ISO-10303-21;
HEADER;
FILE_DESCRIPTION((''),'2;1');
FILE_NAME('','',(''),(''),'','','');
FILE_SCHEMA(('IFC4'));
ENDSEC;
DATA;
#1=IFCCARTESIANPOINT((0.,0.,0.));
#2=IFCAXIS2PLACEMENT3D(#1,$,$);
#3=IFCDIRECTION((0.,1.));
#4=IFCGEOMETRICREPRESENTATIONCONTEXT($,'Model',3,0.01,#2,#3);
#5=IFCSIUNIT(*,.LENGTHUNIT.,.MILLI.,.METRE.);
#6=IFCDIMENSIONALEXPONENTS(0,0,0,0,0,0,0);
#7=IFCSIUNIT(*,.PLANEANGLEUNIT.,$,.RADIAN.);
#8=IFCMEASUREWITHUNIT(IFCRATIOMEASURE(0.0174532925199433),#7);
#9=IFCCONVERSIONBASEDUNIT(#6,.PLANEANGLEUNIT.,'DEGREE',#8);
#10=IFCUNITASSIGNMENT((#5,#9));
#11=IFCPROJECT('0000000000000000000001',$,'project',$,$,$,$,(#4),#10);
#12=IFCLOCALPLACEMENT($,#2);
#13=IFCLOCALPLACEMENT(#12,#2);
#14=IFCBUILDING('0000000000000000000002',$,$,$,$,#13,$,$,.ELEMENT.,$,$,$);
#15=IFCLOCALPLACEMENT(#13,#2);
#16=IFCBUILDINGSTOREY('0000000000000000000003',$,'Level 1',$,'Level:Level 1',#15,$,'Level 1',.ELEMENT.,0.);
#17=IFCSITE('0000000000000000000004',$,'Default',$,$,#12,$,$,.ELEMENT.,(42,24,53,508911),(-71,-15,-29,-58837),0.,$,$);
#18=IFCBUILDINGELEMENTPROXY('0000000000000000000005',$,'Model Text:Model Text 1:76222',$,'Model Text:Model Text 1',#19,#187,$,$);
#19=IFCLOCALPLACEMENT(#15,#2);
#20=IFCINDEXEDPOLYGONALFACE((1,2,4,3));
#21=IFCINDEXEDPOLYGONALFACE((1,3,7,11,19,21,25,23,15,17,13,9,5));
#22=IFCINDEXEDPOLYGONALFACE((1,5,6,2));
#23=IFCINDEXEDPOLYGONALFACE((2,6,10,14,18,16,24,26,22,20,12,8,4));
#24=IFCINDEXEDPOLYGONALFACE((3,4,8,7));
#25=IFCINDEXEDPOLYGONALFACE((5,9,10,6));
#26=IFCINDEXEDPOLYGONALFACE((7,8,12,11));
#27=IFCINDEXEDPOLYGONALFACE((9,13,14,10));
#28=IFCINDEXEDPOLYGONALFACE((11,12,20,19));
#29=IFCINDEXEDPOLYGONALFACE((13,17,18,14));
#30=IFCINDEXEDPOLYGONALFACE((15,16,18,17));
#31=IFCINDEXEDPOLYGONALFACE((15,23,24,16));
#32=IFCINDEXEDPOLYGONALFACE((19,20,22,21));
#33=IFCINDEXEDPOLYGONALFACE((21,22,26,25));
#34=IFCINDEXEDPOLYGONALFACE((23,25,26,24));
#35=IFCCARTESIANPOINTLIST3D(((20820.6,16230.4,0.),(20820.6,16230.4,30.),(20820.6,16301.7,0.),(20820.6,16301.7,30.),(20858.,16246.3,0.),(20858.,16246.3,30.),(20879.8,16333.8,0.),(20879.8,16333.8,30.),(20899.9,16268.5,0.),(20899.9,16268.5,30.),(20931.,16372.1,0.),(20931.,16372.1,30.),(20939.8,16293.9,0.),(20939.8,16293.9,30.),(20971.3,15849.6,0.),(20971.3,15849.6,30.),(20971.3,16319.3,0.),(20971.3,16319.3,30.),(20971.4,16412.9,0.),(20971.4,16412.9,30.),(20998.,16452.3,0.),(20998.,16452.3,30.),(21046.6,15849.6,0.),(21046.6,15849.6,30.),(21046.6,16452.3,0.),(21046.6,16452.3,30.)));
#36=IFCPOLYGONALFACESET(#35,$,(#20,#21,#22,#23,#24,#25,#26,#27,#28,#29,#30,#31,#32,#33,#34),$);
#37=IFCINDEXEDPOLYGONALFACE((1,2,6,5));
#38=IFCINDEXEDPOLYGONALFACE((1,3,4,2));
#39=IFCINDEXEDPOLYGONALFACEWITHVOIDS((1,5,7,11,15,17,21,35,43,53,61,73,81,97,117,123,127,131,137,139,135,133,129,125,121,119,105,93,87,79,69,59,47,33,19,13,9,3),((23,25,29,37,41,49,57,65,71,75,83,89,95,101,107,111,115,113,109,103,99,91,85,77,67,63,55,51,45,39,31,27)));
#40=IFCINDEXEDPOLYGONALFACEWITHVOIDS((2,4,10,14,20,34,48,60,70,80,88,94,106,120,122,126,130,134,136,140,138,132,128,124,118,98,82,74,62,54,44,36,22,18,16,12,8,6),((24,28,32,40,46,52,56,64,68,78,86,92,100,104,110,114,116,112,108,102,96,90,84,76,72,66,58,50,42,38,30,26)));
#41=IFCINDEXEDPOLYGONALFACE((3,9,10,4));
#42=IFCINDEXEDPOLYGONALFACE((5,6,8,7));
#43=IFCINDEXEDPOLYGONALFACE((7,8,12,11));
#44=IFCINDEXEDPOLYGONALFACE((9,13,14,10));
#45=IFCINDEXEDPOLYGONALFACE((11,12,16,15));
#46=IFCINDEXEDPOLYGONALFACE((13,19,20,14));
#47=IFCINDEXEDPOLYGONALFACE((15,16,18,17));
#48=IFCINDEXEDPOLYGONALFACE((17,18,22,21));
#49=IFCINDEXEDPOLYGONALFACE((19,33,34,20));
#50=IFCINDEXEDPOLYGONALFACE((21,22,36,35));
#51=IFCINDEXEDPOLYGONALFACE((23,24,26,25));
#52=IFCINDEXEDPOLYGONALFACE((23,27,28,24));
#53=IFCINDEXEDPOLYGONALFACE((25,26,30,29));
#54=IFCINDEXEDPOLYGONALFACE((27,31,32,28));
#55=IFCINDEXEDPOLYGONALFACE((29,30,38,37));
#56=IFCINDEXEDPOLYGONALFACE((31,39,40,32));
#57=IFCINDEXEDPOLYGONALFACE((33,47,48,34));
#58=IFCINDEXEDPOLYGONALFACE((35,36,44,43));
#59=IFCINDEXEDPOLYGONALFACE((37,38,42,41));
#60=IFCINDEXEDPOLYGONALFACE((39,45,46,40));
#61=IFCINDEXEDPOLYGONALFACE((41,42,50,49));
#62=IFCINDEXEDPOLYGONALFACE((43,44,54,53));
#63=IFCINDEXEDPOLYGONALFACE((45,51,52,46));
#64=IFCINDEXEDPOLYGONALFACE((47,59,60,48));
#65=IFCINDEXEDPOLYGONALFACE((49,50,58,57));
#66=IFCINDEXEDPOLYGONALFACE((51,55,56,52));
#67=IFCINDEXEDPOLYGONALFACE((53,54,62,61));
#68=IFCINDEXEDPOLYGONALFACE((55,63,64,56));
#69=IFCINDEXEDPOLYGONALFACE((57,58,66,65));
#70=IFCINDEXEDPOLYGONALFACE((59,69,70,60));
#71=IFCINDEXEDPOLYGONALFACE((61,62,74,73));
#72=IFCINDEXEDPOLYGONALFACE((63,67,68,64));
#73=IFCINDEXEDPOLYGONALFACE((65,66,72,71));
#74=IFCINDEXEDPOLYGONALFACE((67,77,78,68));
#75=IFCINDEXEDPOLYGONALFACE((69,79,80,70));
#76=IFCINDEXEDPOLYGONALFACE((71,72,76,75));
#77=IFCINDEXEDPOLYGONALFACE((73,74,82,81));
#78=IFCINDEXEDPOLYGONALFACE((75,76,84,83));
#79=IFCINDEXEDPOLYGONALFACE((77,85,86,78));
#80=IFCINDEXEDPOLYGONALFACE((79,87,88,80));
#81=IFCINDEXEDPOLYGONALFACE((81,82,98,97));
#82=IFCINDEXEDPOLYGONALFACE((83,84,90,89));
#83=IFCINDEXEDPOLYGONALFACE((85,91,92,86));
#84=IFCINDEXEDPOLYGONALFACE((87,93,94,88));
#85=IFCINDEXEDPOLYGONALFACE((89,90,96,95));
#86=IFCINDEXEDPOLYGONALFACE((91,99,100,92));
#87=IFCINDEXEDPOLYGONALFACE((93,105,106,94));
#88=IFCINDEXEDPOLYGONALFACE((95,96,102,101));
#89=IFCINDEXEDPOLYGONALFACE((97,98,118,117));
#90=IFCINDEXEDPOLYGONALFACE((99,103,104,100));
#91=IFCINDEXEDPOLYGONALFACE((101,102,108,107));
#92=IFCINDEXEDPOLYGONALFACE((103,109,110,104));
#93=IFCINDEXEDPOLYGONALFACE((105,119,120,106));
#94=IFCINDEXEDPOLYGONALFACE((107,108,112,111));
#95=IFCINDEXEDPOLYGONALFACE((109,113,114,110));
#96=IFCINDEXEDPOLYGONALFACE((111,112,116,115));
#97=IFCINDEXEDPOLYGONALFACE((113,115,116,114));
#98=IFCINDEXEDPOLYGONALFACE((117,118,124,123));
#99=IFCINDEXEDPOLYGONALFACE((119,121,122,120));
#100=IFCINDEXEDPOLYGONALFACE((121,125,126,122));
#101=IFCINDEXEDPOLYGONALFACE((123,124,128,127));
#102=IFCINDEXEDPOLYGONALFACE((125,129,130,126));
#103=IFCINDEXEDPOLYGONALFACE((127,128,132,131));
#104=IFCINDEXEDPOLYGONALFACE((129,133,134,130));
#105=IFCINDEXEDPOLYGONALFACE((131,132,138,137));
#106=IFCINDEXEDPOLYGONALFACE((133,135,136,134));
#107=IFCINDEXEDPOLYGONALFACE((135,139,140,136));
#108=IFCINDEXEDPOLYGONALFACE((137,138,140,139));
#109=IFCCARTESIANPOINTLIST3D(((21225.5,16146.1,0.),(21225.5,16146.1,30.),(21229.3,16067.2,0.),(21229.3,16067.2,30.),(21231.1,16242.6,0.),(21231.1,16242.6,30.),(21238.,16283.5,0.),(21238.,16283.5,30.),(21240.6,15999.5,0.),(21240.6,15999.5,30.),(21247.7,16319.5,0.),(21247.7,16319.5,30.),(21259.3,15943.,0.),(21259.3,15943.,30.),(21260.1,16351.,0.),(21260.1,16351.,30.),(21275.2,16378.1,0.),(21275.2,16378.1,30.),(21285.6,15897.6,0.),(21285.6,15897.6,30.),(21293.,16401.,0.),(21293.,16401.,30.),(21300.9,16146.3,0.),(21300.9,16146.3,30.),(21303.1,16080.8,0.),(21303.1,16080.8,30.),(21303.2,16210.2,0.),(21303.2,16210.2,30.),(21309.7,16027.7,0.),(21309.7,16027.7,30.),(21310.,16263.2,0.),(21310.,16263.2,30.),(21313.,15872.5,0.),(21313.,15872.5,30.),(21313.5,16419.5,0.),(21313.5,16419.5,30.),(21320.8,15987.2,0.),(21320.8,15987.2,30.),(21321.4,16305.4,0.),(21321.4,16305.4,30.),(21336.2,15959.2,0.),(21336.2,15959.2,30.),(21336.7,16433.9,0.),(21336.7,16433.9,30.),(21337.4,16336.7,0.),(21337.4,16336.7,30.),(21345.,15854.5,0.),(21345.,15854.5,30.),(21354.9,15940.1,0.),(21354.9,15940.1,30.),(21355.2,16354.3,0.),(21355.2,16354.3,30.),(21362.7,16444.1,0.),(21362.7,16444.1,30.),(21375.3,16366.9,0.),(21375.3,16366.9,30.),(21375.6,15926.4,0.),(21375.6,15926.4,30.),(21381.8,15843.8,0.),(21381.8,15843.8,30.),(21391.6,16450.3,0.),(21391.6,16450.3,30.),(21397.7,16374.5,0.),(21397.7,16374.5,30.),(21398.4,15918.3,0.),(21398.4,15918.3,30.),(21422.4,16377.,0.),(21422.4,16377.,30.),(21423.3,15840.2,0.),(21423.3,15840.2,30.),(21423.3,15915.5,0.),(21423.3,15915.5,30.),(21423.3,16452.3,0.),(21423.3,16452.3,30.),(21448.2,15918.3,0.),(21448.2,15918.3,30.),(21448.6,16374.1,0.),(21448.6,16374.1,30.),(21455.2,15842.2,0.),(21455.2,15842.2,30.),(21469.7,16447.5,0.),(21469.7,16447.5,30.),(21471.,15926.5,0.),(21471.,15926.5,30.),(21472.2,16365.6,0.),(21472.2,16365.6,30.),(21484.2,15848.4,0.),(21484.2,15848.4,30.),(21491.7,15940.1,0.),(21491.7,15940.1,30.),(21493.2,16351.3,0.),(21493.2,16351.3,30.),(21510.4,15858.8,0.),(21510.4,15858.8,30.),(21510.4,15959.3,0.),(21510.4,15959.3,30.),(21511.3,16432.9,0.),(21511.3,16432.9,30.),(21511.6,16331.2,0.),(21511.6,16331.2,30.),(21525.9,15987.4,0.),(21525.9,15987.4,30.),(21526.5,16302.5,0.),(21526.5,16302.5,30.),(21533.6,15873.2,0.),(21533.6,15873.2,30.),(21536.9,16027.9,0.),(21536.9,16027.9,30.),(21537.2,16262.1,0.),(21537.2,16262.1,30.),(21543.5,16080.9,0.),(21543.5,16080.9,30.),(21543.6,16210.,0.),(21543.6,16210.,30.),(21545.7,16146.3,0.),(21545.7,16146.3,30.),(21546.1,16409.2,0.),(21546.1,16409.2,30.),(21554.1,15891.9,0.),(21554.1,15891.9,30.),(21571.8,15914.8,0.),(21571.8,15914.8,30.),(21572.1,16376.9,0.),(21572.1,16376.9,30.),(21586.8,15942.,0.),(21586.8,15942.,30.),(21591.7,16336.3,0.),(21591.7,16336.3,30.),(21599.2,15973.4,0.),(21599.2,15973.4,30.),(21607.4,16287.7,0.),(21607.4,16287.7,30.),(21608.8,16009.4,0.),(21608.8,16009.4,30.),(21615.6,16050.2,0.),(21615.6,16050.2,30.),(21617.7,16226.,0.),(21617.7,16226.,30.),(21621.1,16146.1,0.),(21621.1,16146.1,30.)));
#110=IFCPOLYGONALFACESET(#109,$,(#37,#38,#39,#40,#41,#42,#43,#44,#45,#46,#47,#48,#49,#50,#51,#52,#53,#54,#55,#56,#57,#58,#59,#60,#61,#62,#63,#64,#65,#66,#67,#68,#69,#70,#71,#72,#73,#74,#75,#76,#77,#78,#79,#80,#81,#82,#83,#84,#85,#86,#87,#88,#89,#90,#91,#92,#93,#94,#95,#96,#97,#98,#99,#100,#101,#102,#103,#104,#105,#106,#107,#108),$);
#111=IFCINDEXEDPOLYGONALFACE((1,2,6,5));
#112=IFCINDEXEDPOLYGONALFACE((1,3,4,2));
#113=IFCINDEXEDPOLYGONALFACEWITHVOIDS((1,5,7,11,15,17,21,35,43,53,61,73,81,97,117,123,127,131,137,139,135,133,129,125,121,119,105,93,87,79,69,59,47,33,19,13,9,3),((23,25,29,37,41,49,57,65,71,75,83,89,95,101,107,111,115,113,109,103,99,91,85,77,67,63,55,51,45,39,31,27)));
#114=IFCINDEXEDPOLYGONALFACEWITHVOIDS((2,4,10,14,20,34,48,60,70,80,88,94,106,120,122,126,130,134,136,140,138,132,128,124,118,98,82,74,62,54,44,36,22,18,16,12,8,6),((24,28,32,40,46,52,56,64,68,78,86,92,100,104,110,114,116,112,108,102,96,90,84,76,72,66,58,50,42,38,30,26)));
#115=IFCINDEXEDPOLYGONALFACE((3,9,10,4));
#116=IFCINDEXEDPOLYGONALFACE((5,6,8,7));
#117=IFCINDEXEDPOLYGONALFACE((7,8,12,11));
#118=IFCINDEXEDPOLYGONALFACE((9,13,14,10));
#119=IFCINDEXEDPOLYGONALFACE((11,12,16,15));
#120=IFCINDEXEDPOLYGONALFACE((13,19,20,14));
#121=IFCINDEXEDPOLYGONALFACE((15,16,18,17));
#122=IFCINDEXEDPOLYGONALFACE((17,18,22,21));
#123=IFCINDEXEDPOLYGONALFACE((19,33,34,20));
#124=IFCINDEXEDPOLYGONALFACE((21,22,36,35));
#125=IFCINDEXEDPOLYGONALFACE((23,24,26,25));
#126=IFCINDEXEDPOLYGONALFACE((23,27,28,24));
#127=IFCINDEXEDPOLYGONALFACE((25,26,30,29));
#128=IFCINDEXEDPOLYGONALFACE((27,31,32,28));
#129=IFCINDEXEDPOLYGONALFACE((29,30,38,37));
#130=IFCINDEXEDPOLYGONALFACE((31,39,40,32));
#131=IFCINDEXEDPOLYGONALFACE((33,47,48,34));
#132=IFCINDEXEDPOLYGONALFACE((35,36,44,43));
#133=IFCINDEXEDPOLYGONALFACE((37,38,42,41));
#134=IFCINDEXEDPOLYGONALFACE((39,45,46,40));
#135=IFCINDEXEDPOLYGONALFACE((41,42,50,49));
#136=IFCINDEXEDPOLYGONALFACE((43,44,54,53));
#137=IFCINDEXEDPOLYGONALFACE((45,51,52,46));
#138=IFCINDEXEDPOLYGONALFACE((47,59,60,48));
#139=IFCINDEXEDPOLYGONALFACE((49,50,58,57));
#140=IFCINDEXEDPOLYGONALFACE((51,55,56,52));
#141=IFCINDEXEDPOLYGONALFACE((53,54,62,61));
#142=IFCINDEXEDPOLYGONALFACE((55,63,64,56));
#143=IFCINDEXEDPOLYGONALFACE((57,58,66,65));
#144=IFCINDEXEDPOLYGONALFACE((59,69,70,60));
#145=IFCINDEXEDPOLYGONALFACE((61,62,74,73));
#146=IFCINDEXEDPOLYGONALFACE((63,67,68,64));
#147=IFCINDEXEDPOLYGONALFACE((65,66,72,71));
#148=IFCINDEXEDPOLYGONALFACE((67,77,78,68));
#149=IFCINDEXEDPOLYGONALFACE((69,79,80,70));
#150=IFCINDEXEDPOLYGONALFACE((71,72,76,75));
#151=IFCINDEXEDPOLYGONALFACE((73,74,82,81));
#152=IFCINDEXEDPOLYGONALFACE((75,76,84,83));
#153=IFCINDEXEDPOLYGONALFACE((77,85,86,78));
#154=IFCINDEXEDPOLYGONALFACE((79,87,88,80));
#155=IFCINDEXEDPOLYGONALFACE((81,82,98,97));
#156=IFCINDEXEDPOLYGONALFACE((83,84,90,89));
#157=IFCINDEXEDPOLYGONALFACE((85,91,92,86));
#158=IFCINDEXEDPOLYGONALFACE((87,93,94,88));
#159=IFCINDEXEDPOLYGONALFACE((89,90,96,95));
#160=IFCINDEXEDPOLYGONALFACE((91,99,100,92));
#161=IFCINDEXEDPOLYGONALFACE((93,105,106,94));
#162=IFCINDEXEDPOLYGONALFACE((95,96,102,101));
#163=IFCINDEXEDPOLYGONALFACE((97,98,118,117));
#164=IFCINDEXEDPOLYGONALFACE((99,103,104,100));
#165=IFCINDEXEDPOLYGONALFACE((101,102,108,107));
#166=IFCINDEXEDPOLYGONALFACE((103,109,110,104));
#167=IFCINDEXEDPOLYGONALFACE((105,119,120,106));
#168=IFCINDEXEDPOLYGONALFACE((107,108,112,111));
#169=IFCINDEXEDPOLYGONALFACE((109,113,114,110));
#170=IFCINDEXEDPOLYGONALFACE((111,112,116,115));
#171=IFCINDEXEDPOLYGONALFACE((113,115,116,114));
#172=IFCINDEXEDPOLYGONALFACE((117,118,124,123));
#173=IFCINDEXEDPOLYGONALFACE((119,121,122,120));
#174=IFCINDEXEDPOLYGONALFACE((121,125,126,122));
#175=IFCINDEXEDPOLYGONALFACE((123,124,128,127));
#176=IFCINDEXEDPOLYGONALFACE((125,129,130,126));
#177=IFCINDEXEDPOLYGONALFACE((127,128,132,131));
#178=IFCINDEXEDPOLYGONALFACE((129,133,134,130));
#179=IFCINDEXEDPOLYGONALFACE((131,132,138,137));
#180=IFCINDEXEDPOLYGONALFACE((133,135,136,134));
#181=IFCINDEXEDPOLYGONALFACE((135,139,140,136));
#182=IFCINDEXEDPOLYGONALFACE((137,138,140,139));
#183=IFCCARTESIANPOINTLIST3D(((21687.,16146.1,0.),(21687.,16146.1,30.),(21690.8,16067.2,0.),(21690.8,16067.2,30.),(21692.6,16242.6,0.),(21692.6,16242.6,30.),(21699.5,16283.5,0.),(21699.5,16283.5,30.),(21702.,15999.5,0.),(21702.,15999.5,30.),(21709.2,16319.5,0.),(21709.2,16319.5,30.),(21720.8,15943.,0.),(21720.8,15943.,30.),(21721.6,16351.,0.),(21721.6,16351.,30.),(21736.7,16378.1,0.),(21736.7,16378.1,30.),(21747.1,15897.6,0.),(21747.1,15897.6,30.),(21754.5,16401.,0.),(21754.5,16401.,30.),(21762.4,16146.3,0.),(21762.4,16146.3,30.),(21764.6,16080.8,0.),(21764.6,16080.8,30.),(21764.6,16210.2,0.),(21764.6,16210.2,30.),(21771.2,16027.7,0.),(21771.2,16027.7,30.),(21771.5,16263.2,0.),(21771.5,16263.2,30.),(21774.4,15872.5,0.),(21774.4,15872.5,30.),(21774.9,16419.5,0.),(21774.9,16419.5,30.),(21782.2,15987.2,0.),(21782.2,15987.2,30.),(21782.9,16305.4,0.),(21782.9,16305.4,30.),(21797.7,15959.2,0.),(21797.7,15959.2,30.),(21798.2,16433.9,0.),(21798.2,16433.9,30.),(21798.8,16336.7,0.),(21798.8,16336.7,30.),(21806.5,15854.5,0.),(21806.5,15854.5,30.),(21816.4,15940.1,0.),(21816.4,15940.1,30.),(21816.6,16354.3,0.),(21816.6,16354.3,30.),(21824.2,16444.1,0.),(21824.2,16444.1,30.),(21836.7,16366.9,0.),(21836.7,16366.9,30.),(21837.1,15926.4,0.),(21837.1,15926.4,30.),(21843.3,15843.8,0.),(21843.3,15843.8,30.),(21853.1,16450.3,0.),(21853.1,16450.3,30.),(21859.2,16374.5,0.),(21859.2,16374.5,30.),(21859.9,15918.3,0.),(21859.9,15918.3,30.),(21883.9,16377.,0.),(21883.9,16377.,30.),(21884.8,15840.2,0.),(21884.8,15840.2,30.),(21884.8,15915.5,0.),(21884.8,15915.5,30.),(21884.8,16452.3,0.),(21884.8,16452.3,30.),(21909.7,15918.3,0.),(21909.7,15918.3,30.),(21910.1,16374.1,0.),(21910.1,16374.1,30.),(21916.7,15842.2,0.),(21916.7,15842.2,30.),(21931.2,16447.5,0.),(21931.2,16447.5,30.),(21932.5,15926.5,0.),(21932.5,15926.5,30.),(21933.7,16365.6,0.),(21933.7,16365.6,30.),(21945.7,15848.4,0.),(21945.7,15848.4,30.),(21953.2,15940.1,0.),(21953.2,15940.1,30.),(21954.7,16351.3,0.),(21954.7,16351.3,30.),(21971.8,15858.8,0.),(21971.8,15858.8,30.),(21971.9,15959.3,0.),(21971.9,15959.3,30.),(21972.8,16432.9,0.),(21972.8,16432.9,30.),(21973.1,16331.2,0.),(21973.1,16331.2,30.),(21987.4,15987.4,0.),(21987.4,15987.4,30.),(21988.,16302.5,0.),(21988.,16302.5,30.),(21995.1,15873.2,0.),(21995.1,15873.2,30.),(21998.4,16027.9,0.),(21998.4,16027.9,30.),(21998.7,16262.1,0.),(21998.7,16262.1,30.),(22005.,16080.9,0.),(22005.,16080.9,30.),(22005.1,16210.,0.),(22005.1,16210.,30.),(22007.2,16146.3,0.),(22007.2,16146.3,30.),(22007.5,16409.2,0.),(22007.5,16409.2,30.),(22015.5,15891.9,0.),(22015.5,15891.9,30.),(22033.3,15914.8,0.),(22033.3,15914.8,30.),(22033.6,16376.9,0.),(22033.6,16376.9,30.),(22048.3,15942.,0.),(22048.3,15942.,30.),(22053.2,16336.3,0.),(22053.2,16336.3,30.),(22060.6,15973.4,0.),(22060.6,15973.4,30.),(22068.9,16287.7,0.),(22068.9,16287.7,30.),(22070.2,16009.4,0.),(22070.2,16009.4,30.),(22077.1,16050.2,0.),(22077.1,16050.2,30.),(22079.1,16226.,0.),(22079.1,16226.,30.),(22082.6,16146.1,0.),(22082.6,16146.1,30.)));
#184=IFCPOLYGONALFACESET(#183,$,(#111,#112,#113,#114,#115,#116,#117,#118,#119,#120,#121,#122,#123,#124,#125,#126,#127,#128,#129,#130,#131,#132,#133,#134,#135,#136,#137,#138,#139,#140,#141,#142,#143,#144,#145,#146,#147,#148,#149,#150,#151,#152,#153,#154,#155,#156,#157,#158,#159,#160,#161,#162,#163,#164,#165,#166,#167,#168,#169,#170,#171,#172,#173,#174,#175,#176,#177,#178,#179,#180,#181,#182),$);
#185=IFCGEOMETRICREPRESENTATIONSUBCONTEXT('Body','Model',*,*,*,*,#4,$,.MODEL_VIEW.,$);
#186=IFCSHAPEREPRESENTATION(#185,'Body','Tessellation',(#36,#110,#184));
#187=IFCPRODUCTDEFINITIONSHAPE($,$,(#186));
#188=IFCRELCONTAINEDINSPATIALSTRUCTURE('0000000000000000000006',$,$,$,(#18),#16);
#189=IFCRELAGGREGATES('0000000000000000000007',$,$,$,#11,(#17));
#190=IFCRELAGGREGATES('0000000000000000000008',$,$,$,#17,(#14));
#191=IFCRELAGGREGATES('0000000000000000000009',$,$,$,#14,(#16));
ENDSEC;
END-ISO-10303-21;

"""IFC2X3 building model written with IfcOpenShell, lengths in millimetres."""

from ifc_helpers import new_model, entity, si_unit, converted_unit, direction, frame, origin, place, context, subcontext, project, spatial, polyline, outline, extrude, element, save


model = new_model("IFC2X3")

# Units and contexts
model_context = context("Model", 3, precision=0.01, world=origin(), true_north=direction((0.0, 1.0)))
body_context = subcontext(model_context, "Body", "Model", "MODEL_VIEW")
ifc_project = project(units=[si_unit("LENGTHUNIT", "METRE", prefix="MILLI"), converted_unit("PLANEANGLEUNIT", "DEGREE", entity("IfcRatioMeasure", 0.0174532925199433), si_unit("PLANEANGLEUNIT", "RADIAN"), dimensions=[0, 0, 0, 0, 0, 0, 0])], contexts=[model_context])

# Site, building, storey
site_placement = place(None, origin())
site = spatial("IfcSite", under=ifc_project, at=site_placement, Name="Default", CompositionType="ELEMENT", RefLatitude=(42, 24, 53, 508911), RefLongitude=(-71, -15, -29, -58837), RefElevation=0.0)
building_placement = place(site_placement, origin())
building = spatial("IfcBuilding", under=site, at=building_placement, CompositionType="ELEMENT")
storey_placement = place(building_placement, origin())
storey = spatial("IfcBuildingStorey", under=building, at=storey_placement, Name="Level 1", ObjectType="Level:Level 1", LongName="Level 1", CompositionType="ELEMENT", Elevation=0.0)

# Building element proxy
proxy_1_placement = place(storey_placement, origin())
element("IfcBuildingElementProxy", 1, at=proxy_1_placement, inside=storey, Name="Model Text:Model Text 1:76222", ObjectType="Model Text:Model Text 1", context=body_context, shape_type="SweptSolid", body=[
    extrude(outline(polyline([(-410.6, -111.6), (192.1, -111.6), (192.1, -63.1), (152.7, -36.4), (111.9, 4.0), (73.6, 55.2), (41.4, 114.4), (-29.8, 114.4), (-13.9, 77.0), (8.3, 35.1), (33.7, -4.8), (59.1, -36.3), (-410.6, -36.3), (-410.6, -111.6)])), frame((20935.0, 16260.2, 0.0), z_axis=(0.0, 0.0, 1.0), x_axis=(0.0, 1.0, 0.0)), (0.0, 0.0, 1.0), 30.0),
    extrude(outline(polyline([(-10.6, -198.7), (68.3, -198.7), (136.5, -190.7), (193.9, -174.7), (240.5, -150.6), (266.9, -124.4), (286.3, -93.2), (298.8, -57.0), (304.3, -15.7), (303.8, 16.2), (299.0, 45.5), (289.9, 72.1), (276.6, 96.0), (258.9, 117.3), (236.9, 136.2), (210.4, 152.5), (179.6, 166.3), (144.1, 177.6), (103.7, 186.3), (8.2, 196.4), (-71.8, 196.7), (-134.0, 189.4), (-183.3, 176.1), (-224.7, 158.4), (-258.2, 133.9), (-283.5, 100.3), (-300.1, 59.5), (-307.1, 13.4), (-306.6, -18.4), (-301.8, -47.5), (-292.8, -74.0), (-279.6, -97.9), (-262.0, -119.2), (-240.0, -138.1), (-213.6, -154.5), (-182.8, -168.4), (-147.3, -179.8), (-106.7, -188.6), (-10.6, -198.7)]), holes=[polyline([(-7.2, -123.5), (-71.0, -118.2), (-123.6, -108.8), (-165.2, -95.4), (-195.7, -78.0), (-212.4, -59.4), (-224.1, -38.7), (-230.6, -15.9), (-231.9, 8.9), (-227.8, 35.0), (-218.1, 58.1), (-202.8, 78.4), (-182.0, 95.8), (-152.6, 109.4), (-111.7, 118.1), (-59.4, 122.0), (4.4, 121.1), (69.6, 115.8), (122.2, 106.7), (162.2, 93.7), (189.5, 77.0), (207.7, 57.4), (220.4, 36.0), (227.5, 12.8), (229.1, -12.1), (225.2, -36.8), (215.9, -59.2), (201.3, -79.3), (181.4, -97.1), (152.6, -111.2), (111.6, -120.3), (58.3, -124.4), (-7.2, -123.5)])]), frame((21424.6, 16144.9, 0.0), z_axis=(0.0, 0.0, 1.0), x_axis=(0.047515, -0.998871, 0.0)), (0.0, 0.0, 1.0), 30.0),
    extrude(outline(polyline([(-10.6, -198.7), (68.3, -198.7), (136.5, -190.7), (193.9, -174.7), (240.5, -150.6), (266.9, -124.4), (286.3, -93.2), (298.8, -57.0), (304.3, -15.7), (303.8, 16.2), (299.0, 45.5), (289.9, 72.1), (276.6, 96.0), (258.9, 117.3), (236.9, 136.2), (210.4, 152.5), (179.6, 166.3), (144.1, 177.6), (103.7, 186.3), (8.2, 196.4), (-71.8, 196.7), (-134.0, 189.4), (-183.3, 176.1), (-224.7, 158.4), (-258.2, 133.9), (-283.5, 100.3), (-300.1, 59.5), (-307.1, 13.4), (-306.6, -18.4), (-301.8, -47.5), (-292.8, -74.0), (-279.6, -97.9), (-262.0, -119.2), (-240.0, -138.1), (-213.6, -154.5), (-182.8, -168.4), (-147.3, -179.8), (-106.7, -188.6), (-10.6, -198.7)]), holes=[polyline([(-7.2, -123.5), (-71.0, -118.2), (-123.6, -108.8), (-165.2, -95.4), (-195.7, -78.0), (-212.4, -59.4), (-224.1, -38.7), (-230.6, -15.9), (-231.9, 8.9), (-227.8, 35.0), (-218.1, 58.1), (-202.8, 78.4), (-182.0, 95.8), (-152.6, 109.4), (-111.7, 118.1), (-59.4, 122.0), (4.4, 121.1), (69.6, 115.8), (122.2, 106.7), (162.2, 93.7), (189.5, 77.0), (207.7, 57.4), (220.4, 36.0), (227.5, 12.8), (229.1, -12.1), (225.2, -36.8), (215.9, -59.2), (201.3, -79.3), (181.4, -97.1), (152.6, -111.2), (111.6, -120.3), (58.3, -124.4), (-7.2, -123.5)])]), frame((21886.0, 16144.9, 0.0), z_axis=(0.0, 0.0, 1.0), x_axis=(0.047515, -0.998871, 0.0)), (0.0, 0.0, 1.0), 30.0),
])

save(model, "model.ifc")
